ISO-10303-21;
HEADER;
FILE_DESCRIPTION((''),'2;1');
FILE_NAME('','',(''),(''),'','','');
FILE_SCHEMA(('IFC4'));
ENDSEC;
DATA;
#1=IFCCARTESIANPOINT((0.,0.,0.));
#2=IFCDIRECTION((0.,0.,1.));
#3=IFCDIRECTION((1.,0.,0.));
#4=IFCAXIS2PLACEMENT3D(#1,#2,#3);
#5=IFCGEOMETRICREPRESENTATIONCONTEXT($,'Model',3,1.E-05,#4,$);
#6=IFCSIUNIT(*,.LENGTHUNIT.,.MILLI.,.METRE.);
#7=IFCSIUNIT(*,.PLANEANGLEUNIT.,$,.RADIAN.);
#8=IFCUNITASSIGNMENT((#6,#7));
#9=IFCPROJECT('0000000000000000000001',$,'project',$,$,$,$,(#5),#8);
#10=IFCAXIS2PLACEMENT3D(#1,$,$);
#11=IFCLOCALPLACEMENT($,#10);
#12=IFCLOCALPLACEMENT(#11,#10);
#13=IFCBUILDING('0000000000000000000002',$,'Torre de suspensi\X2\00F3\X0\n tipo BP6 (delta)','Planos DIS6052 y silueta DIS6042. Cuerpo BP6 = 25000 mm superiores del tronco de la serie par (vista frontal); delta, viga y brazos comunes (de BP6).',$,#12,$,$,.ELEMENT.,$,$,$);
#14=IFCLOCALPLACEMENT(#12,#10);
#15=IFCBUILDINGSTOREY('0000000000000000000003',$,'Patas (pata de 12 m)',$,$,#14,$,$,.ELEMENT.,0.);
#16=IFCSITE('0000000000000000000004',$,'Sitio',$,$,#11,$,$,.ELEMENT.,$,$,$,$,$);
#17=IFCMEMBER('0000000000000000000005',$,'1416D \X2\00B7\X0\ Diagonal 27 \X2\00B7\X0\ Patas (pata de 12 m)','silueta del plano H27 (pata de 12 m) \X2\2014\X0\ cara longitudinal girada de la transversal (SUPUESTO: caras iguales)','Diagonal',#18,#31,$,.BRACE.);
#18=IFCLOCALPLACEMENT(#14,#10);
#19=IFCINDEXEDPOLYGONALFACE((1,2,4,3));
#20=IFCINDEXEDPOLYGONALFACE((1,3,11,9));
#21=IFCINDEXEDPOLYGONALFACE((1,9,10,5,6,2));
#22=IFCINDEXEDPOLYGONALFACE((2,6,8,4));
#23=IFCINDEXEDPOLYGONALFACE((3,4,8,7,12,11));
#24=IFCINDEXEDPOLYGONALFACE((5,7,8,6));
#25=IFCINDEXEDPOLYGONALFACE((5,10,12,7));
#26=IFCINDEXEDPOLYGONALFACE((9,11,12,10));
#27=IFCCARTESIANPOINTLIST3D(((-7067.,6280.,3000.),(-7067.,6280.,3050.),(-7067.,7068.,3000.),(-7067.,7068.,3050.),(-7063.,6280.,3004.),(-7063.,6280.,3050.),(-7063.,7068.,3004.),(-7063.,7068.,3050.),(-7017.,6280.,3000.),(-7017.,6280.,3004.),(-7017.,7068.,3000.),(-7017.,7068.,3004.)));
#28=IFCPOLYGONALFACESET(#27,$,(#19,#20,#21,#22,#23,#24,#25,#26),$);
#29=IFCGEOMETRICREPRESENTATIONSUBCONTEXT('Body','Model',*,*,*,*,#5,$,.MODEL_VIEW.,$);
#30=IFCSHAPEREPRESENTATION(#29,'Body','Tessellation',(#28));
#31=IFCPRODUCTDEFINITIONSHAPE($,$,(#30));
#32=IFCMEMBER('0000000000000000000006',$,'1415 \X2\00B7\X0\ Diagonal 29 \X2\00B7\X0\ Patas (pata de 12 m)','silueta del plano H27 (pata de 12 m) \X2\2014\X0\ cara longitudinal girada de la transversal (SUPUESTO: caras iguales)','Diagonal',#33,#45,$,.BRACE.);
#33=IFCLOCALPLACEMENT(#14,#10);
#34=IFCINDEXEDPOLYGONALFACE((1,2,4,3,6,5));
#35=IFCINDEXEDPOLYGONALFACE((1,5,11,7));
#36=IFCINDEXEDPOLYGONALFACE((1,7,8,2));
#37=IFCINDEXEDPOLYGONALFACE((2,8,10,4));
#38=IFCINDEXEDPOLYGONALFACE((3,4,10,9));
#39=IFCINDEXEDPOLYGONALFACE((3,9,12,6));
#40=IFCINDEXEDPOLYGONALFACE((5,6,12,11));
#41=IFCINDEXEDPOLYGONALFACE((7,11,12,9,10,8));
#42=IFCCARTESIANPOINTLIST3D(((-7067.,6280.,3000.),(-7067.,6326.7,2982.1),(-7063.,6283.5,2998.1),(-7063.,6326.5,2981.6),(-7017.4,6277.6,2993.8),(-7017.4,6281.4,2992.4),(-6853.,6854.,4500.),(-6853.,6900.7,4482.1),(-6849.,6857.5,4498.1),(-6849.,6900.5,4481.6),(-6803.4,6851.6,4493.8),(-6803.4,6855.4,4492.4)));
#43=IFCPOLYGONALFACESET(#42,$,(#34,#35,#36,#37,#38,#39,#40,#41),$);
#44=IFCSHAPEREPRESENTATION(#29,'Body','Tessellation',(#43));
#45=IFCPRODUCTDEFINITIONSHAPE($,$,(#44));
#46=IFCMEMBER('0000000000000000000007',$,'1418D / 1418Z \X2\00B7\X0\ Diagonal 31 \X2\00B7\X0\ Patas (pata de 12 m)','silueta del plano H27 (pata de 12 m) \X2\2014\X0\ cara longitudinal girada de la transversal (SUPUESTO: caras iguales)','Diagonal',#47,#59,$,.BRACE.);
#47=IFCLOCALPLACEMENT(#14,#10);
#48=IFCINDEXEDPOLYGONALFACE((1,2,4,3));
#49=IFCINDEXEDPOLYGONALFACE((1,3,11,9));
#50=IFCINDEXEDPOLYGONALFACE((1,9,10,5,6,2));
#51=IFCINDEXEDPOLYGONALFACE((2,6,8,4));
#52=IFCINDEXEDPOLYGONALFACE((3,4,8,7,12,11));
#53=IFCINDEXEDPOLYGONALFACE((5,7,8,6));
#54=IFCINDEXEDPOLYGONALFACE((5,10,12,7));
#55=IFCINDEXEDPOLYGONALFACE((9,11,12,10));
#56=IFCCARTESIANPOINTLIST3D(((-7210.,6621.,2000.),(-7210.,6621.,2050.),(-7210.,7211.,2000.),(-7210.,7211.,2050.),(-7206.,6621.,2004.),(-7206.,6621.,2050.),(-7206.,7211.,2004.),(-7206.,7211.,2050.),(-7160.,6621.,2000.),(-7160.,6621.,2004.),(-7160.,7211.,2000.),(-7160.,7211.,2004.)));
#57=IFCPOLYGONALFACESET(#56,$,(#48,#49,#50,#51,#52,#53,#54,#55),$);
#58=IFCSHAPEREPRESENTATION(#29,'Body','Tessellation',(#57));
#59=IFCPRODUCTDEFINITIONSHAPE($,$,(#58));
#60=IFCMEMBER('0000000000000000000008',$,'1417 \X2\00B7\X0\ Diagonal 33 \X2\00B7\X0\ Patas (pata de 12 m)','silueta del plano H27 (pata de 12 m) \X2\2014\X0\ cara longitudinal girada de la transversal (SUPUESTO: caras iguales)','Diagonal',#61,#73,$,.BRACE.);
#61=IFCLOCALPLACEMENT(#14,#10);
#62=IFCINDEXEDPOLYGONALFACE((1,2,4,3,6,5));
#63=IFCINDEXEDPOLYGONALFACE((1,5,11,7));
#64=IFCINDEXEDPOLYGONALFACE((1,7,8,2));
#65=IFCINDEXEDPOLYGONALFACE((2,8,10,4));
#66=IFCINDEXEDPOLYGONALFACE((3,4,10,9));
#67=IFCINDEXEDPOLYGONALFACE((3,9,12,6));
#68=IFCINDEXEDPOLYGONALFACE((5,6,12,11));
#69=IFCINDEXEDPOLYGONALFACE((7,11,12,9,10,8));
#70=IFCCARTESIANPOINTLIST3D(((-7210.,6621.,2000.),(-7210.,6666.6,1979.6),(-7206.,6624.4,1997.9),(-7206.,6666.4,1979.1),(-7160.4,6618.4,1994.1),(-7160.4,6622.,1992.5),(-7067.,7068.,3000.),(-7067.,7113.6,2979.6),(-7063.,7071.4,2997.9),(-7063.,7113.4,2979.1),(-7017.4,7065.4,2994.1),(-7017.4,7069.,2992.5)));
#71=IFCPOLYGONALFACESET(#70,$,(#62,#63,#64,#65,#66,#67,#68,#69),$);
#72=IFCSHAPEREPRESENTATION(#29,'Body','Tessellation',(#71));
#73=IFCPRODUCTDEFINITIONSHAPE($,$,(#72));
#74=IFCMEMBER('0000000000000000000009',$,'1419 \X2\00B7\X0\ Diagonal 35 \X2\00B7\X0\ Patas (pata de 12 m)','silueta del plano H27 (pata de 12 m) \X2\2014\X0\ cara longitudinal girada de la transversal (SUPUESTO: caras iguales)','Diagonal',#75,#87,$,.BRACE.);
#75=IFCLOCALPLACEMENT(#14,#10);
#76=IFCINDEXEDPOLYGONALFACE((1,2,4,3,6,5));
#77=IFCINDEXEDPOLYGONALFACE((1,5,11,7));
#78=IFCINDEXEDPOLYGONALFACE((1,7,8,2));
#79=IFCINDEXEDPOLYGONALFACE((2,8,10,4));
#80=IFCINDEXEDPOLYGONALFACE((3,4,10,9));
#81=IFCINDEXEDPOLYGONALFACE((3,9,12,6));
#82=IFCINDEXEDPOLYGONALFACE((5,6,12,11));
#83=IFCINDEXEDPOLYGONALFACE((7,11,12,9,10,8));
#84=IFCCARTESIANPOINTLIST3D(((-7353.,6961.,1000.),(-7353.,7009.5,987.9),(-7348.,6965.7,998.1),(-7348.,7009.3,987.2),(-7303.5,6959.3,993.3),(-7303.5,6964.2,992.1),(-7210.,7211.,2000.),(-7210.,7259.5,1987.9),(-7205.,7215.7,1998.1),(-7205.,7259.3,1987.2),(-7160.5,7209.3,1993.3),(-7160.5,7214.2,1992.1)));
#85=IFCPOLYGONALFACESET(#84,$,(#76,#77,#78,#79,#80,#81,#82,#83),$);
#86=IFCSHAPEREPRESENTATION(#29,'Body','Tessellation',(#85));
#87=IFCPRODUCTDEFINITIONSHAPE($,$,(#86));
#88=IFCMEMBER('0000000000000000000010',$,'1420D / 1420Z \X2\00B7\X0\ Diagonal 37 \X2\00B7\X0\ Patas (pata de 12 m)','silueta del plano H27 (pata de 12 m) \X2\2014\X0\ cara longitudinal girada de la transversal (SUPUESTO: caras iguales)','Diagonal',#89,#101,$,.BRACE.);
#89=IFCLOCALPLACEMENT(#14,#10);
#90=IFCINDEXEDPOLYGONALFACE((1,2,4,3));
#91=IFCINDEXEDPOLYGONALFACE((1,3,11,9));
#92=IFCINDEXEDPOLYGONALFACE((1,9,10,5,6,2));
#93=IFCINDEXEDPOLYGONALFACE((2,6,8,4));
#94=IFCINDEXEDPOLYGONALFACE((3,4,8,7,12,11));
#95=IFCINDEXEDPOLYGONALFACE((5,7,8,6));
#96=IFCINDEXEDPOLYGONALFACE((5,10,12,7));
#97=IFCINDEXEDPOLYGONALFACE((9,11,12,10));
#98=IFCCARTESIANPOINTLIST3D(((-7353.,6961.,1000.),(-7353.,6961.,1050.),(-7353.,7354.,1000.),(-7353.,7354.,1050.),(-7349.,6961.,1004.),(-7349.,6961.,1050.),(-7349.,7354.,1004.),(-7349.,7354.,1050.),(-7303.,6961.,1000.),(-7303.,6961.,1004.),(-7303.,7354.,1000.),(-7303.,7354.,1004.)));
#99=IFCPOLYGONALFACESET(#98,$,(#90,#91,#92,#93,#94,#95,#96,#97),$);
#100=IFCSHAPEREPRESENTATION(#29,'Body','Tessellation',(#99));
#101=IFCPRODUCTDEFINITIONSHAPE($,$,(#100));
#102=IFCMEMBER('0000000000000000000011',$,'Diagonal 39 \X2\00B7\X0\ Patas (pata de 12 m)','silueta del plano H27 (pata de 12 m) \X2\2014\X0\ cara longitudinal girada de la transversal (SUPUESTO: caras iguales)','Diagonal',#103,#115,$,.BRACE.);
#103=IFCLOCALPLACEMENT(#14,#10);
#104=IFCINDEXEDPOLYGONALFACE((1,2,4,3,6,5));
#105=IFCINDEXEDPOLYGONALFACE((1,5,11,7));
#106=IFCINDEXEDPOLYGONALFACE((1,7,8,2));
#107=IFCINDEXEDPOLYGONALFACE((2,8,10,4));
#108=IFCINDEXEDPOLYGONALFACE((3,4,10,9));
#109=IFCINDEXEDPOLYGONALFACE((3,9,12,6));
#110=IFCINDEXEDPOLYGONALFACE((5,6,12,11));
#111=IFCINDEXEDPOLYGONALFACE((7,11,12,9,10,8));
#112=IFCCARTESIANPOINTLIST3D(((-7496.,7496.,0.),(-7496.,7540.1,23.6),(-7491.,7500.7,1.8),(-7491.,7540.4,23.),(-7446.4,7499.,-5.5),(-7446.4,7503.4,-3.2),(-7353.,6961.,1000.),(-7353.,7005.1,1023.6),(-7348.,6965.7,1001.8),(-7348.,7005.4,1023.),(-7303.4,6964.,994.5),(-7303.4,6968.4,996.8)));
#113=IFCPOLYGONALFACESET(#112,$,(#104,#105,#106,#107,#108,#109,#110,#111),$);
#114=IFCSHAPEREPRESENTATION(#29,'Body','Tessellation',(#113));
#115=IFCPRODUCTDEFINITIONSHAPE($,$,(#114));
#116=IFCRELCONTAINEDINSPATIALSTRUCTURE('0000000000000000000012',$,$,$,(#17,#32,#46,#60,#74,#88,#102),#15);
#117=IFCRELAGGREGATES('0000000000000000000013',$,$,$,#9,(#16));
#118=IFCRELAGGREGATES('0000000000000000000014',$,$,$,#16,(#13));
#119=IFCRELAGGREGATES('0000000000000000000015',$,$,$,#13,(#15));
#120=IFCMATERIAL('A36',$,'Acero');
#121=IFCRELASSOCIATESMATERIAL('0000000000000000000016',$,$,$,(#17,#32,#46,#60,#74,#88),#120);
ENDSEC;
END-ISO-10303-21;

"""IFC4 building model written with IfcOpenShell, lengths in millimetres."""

from ifc_helpers import new_model, si_unit, frame, frame_2d, origin, origin_with_axes, place, context, subcontext, project, spatial, l_section, extrude, material, element, save


model = new_model("IFC4")

# Units and contexts
model_context = context("Model", 3, precision=1e-05, world=origin_with_axes())
body_context = subcontext(model_context, "Body", "Model", "MODEL_VIEW")
ifc_project = project(units=[si_unit("LENGTHUNIT", "METRE", prefix="MILLI"), si_unit("PLANEANGLEUNIT", "RADIAN")], contexts=[model_context])

# Site, building, storey
site_placement = place(None, origin())
site = spatial("IfcSite", under=ifc_project, at=site_placement, Name="Sitio", CompositionType="ELEMENT")
building_placement = place(site_placement, origin())
building = spatial("IfcBuilding", under=site, at=building_placement, Name="Torre de suspensión tipo BP6 (delta)", Description="Planos DIS6052 y silueta DIS6042. Cuerpo BP6 = 25000 mm superiores del tronco de la serie par (vista frontal); delta, viga y brazos comunes (de BP6).", CompositionType="ELEMENT")
storey_placement = place(building_placement, origin())
storey = spatial("IfcBuildingStorey", under=building, at=storey_placement, Name="Patas (pata de 12 m)", CompositionType="ELEMENT", Elevation=0.0)

# Members
ifc_material = material(Name="A36", Category="Acero")
member_1_placement = place(storey_placement, frame((-7067.0, 7068.0, 3000.0), z_axis=(0.0, -1.0, 0.0), x_axis=(1.0, 0.0, 0.0)))
element("IfcMember", 1, at=member_1_placement, inside=storey, material=ifc_material, Name="1416D · Diagonal 27 · Patas (pata de 12 m)", Description="silueta del plano H27 (pata de 12 m) — cara longitudinal girada de la transversal (SUPUESTO: caras iguales)", ObjectType="Diagonal", PredefinedType="BRACE", context=body_context, shape_type="SweptSolid", body=[
    extrude(l_section(Depth=50.0, Width=50.0, Thickness=4.0, at=frame_2d((25.0, 25.0))), None, (0.0, 0.0, 1.0), 788.0),
])
member_2_placement = place(storey_placement, frame((-7067.0, 6280.0, 3000.0), z_axis=(0.132077, 0.354262, 0.925772), x_axis=(0.991239, -0.047203, -0.123354)))
element("IfcMember", 2, at=member_2_placement, inside=storey, material=ifc_material, Name="1415 · Diagonal 29 · Patas (pata de 12 m)", Description="silueta del plano H27 (pata de 12 m) — cara longitudinal girada de la transversal (SUPUESTO: caras iguales)", ObjectType="Diagonal", PredefinedType="BRACE", context=body_context, shape_type="SweptSolid", body=[
    extrude(l_section(Depth=50.0, Width=50.0, Thickness=4.0, at=frame_2d((25.0, 25.0))), None, (0.0, 0.0, 1.0), 1620.3),
])
member_3_placement = place(storey_placement, frame((-7210.0, 7211.0, 2000.0), z_axis=(0.0, -1.0, 0.0), x_axis=(1.0, 0.0, 0.0)))
element("IfcMember", 3, at=member_3_placement, inside=storey, material=ifc_material, Name="1418D / 1418Z · Diagonal 31 · Patas (pata de 12 m)", Description="silueta del plano H27 (pata de 12 m) — cara longitudinal girada de la transversal (SUPUESTO: caras iguales)", ObjectType="Diagonal", PredefinedType="BRACE", context=body_context, shape_type="SweptSolid", body=[
    extrude(l_section(Depth=50.0, Width=50.0, Thickness=4.0, at=frame_2d((25.0, 25.0))), None, (0.0, 0.0, 1.0), 590.0),
])
member_4_placement = place(storey_placement, frame((-7210.0, 6621.0, 2000.0), z_axis=(0.129452, 0.404652, 0.905262), x_axis=(0.991586, -0.052828, -0.118183)))
element("IfcMember", 4, at=member_4_placement, inside=storey, material=ifc_material, Name="1417 · Diagonal 33 · Patas (pata de 12 m)", Description="silueta del plano H27 (pata de 12 m) — cara longitudinal girada de la transversal (SUPUESTO: caras iguales)", ObjectType="Diagonal", PredefinedType="BRACE", context=body_context, shape_type="SweptSolid", body=[
    extrude(l_section(Depth=50.0, Width=50.0, Thickness=4.0, at=frame_2d((25.0, 25.0))), None, (0.0, 0.0, 1.0), 1104.7),
])
member_5_placement = place(storey_placement, frame((-7353.0, 6961.0, 1000.0), z_axis=(0.137414, 0.240235, 0.960939), x_axis=(0.990514, -0.033328, -0.133311)))
element("IfcMember", 5, at=member_5_placement, inside=storey, material=ifc_material, Name="1419 · Diagonal 35 · Patas (pata de 12 m)", Description="silueta del plano H27 (pata de 12 m) — cara longitudinal girada de la transversal (SUPUESTO: caras iguales)", ObjectType="Diagonal", PredefinedType="BRACE", context=body_context, shape_type="SweptSolid", body=[
    extrude(l_section(Depth=50.0, Width=50.0, Thickness=5.0, at=frame_2d((25.0, 25.0))), None, (0.0, 0.0, 1.0), 1040.6),
])
member_6_placement = place(storey_placement, frame((-7353.0, 7354.0, 1000.0), z_axis=(0.0, -1.0, 0.0), x_axis=(1.0, 0.0, 0.0)))
element("IfcMember", 6, at=member_6_placement, inside=storey, material=ifc_material, Name="1420D / 1420Z · Diagonal 37 · Patas (pata de 12 m)", Description="silueta del plano H27 (pata de 12 m) — cara longitudinal girada de la transversal (SUPUESTO: caras iguales)", ObjectType="Diagonal", PredefinedType="BRACE", context=body_context, shape_type="SweptSolid", body=[
    extrude(l_section(Depth=50.0, Width=50.0, Thickness=4.0, at=frame_2d((25.0, 25.0))), None, (0.0, 0.0, 1.0), 393.0),
])
member_7_placement = place(storey_placement, frame((-7496.0, 7496.0, 0.0), z_axis=(0.125099, -0.468026, 0.874815), x_axis=(0.992144, 0.059013, -0.110305)))
element("IfcMember", 7, at=member_7_placement, inside=storey, Name="Diagonal 39 · Patas (pata de 12 m)", Description="silueta del plano H27 (pata de 12 m) — cara longitudinal girada de la transversal (SUPUESTO: caras iguales)", ObjectType="Diagonal", PredefinedType="BRACE", context=body_context, shape_type="SweptSolid", body=[
    extrude(l_section(Depth=50.0, Width=50.0, Thickness=5.0, at=frame_2d((25.0, 25.0))), None, (0.0, 0.0, 1.0), 1143.1),
])

save(model, "model.ifc")
